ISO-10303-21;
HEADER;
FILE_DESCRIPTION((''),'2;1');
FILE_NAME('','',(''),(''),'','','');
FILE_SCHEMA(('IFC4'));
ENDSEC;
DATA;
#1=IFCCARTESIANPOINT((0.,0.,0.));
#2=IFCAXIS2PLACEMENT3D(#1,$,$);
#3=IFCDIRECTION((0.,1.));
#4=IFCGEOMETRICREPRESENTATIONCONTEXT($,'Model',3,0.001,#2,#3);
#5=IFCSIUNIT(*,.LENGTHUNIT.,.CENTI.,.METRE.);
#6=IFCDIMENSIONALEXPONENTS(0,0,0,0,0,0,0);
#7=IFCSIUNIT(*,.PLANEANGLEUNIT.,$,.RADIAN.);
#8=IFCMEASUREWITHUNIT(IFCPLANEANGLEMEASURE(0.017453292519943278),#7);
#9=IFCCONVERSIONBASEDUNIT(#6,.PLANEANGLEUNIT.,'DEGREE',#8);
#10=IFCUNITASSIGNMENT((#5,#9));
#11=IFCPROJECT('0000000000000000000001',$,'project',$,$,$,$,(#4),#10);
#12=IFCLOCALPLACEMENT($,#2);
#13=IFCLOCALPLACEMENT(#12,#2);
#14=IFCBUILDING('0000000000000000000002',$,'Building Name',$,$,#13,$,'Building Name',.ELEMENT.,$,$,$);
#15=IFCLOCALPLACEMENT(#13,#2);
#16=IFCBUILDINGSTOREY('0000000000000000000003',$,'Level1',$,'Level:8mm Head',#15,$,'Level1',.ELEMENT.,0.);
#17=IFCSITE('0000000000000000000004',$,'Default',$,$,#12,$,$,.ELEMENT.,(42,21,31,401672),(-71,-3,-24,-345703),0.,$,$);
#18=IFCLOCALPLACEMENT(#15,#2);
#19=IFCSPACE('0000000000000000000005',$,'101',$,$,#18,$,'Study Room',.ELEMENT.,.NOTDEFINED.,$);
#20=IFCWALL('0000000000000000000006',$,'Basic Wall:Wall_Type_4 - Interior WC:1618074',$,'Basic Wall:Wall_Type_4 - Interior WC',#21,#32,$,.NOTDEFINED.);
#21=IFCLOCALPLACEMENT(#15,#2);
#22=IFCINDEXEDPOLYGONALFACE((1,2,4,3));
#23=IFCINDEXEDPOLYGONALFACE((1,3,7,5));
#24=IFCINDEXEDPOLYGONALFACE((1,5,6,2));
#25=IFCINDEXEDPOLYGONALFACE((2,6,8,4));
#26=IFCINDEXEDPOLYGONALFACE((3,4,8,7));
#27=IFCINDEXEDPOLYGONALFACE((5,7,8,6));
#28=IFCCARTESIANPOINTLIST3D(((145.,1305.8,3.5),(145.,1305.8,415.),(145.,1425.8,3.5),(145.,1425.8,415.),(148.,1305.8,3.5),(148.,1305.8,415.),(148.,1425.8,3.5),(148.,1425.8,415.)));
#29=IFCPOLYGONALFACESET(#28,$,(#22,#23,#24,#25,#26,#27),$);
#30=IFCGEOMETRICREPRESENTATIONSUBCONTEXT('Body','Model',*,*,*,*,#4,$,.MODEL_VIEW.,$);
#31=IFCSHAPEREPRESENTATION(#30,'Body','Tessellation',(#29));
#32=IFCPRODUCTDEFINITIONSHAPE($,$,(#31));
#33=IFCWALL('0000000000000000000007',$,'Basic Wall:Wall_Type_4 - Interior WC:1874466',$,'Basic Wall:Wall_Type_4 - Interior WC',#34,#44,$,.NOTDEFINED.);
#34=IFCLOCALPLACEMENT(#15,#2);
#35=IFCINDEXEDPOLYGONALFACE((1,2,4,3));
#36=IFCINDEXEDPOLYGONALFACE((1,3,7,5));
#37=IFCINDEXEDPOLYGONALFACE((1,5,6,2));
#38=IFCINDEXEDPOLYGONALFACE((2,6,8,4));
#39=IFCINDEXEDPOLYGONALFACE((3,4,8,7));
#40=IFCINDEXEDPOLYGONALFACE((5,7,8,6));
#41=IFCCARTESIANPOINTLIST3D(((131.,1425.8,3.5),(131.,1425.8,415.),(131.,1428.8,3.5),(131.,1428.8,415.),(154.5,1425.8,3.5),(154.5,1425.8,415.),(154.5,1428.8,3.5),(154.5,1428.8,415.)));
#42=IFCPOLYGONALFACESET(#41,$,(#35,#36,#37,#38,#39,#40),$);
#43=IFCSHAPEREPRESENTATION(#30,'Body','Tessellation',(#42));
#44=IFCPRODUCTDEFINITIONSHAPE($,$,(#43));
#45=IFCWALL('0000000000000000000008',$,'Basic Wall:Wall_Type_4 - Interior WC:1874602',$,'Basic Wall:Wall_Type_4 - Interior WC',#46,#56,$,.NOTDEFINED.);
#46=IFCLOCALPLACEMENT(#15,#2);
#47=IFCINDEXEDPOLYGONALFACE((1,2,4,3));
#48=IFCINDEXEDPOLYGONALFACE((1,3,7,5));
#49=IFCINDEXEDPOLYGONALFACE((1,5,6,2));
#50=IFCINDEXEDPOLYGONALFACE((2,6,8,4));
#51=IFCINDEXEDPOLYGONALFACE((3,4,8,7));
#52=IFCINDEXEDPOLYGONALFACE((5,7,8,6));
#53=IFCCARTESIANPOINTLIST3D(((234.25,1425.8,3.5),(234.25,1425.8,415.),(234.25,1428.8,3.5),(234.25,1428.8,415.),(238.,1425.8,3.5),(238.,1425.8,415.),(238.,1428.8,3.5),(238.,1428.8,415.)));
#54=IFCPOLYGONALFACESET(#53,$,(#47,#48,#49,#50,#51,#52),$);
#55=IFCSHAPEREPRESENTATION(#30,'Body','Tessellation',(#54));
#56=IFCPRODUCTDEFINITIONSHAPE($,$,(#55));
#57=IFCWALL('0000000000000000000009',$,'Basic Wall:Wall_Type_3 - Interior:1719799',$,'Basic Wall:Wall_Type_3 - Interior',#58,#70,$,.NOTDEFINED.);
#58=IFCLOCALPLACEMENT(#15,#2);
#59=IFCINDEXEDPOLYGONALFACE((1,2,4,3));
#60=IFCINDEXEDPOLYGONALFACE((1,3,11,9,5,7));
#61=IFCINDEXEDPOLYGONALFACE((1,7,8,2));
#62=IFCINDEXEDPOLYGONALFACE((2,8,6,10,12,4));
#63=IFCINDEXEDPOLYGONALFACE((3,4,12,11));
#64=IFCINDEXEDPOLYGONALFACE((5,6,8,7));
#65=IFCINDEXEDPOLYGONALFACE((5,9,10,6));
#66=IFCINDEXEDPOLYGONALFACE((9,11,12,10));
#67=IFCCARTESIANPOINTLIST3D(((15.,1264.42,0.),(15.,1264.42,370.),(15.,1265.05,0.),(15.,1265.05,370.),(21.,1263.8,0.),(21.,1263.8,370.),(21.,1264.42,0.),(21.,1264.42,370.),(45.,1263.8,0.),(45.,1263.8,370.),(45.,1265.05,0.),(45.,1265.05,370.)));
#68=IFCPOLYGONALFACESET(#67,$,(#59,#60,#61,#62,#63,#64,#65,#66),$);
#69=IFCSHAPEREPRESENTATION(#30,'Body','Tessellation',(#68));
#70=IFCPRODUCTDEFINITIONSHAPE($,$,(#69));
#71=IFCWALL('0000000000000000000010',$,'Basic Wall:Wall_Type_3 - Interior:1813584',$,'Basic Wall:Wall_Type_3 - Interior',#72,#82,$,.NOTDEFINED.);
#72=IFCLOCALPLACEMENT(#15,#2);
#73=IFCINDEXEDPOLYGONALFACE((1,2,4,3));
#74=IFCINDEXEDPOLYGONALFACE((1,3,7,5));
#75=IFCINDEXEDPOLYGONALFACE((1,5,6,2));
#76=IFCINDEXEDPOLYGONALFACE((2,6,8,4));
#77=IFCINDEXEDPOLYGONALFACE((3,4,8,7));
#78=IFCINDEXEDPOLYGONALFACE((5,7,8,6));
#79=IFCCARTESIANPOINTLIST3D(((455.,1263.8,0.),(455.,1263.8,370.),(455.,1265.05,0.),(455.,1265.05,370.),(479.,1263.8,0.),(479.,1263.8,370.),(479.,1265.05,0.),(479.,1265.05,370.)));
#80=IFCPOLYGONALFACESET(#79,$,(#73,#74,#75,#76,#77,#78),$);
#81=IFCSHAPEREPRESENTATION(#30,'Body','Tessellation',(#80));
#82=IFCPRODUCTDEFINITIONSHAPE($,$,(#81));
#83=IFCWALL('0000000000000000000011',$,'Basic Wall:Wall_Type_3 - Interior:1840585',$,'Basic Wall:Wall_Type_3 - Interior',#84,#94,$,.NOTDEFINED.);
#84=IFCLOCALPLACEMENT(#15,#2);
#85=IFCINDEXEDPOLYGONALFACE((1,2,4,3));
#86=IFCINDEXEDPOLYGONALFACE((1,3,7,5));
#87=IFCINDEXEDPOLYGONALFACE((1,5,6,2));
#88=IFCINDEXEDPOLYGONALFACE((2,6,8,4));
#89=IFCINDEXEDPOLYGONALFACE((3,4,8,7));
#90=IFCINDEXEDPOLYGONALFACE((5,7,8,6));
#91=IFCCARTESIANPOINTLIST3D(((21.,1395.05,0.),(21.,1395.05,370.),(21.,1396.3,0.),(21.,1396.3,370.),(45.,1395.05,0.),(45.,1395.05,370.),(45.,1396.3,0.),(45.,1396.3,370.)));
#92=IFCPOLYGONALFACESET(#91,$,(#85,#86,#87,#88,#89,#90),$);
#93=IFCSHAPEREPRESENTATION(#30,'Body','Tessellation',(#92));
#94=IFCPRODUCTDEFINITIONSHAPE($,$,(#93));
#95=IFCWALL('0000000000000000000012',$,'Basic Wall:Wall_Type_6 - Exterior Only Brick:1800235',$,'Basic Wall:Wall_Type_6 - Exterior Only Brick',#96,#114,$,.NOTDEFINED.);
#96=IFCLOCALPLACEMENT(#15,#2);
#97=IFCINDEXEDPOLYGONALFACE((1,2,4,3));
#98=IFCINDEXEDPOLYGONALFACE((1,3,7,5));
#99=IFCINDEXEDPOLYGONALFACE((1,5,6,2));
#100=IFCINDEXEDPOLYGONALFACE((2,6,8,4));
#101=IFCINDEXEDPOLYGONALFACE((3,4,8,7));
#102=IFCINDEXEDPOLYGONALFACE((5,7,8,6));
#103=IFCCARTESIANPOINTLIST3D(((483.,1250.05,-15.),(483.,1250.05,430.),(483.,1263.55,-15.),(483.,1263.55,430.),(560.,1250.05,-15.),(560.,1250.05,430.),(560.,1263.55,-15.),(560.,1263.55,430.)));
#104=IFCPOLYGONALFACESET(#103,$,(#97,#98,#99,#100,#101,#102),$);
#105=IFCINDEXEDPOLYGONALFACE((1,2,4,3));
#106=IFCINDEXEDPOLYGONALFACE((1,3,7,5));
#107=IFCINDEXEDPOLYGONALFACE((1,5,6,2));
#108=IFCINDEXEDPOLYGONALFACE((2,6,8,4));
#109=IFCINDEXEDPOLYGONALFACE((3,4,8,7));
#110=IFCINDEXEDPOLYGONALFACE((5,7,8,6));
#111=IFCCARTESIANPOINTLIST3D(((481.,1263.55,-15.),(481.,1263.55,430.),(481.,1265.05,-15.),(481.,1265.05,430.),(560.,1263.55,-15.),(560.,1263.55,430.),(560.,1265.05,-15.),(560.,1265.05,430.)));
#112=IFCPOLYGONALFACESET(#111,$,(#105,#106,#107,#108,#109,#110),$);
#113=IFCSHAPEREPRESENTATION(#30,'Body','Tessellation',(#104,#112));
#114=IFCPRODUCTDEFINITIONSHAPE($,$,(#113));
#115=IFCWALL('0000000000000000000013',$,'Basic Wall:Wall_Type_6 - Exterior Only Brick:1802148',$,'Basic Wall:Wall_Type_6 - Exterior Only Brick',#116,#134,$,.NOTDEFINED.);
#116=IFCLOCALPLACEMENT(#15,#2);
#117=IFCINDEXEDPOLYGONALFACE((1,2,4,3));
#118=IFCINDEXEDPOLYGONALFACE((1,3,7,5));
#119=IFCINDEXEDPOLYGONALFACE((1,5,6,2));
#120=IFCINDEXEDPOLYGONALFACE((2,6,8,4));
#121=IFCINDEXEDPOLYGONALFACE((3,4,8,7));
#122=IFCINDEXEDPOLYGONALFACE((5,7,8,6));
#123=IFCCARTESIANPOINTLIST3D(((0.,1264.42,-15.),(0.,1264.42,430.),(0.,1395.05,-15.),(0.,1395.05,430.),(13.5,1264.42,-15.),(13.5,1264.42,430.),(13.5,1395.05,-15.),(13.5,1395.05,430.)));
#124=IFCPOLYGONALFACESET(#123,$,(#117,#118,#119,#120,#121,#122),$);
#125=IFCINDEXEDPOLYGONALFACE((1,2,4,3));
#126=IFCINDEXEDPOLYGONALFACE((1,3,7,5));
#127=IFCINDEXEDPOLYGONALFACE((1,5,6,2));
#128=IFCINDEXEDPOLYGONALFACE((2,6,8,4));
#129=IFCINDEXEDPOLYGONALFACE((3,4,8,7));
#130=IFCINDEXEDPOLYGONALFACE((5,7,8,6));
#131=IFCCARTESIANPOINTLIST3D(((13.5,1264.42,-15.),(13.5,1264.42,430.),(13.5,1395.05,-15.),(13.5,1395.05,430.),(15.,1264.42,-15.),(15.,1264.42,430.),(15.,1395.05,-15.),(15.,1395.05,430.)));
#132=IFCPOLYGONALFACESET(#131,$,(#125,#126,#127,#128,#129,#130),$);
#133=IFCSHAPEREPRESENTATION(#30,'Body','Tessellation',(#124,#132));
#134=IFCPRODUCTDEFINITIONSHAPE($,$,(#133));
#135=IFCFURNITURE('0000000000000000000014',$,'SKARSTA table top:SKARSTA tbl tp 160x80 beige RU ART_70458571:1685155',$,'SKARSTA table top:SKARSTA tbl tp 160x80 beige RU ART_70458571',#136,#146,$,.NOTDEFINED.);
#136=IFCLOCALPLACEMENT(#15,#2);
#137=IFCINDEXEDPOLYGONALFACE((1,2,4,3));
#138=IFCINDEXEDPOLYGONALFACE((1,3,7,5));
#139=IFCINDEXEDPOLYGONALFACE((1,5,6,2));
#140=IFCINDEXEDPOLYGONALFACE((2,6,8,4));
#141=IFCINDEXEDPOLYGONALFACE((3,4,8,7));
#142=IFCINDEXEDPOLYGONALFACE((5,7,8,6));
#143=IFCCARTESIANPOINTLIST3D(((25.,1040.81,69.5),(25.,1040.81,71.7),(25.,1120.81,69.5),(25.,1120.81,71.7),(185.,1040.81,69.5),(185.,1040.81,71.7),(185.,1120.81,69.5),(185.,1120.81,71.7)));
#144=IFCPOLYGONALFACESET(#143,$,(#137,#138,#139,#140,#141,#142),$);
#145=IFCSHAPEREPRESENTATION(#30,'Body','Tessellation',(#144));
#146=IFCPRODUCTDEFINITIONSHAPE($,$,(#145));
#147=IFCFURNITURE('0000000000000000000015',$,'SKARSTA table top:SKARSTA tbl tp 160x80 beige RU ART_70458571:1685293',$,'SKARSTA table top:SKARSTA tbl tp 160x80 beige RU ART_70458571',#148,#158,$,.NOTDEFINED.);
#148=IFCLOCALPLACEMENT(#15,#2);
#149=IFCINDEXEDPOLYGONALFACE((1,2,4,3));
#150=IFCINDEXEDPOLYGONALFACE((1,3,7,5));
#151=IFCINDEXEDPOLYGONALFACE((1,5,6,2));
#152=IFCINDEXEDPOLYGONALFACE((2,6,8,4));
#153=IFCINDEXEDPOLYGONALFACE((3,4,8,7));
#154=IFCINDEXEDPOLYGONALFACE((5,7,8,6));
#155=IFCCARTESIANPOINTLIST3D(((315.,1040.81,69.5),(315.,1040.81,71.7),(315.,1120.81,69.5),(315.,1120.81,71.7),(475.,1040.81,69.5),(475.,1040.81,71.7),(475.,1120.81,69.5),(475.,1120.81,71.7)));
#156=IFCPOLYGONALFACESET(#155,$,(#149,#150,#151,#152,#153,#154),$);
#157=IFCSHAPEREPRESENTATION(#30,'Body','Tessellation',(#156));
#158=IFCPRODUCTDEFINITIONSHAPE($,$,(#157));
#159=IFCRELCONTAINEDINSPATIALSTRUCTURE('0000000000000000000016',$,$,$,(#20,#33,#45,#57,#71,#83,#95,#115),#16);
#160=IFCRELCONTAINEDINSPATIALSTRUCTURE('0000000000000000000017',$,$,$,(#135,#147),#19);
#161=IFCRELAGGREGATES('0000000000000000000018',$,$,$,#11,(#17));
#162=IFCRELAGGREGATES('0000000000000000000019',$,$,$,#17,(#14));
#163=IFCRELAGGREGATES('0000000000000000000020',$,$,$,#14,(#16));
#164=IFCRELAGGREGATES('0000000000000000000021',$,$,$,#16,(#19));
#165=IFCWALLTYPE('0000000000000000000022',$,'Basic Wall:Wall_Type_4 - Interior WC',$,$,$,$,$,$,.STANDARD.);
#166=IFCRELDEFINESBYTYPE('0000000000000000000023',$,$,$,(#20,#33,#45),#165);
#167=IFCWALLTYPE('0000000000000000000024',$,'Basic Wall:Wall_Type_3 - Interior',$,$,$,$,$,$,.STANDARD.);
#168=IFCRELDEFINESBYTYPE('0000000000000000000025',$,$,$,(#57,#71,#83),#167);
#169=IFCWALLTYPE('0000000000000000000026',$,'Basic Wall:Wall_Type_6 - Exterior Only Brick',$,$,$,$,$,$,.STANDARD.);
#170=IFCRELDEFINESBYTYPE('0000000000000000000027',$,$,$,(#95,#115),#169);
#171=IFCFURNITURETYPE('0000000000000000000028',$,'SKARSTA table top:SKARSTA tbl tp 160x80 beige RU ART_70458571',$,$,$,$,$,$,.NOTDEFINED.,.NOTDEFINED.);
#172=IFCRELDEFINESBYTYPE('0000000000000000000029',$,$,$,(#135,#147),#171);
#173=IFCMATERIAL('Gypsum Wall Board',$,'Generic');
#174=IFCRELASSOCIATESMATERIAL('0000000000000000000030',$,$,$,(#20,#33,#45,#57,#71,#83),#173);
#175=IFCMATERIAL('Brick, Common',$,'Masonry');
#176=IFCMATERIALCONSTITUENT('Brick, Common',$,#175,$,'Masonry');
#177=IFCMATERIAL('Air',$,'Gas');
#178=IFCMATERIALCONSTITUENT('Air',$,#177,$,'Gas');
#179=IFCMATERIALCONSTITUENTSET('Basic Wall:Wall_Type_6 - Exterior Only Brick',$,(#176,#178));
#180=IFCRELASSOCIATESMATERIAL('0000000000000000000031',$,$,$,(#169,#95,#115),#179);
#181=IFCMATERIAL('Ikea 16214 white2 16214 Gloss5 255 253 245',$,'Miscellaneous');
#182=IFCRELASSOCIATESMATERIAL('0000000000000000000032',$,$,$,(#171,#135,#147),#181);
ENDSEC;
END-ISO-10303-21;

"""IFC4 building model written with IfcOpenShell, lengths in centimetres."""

from ifc_helpers import new_model, entity, si_unit, converted_unit, direction, frame, origin, place, context, subcontext, project, spatial, indexed_curve, outline, extrude, source, transform, mapped, material, constituent, constituent_set, type_object, type_shapes, element, save


model = new_model("IFC4")

# Units and contexts
model_context = context("Model", 3, precision=0.001, world=origin(), true_north=direction((0.0, 1.0)))
body_context = subcontext(model_context, "Body", "Model", "MODEL_VIEW")
ifc_project = project(units=[si_unit("LENGTHUNIT", "METRE", prefix="CENTI"), converted_unit("PLANEANGLEUNIT", "DEGREE", entity("IfcPlaneAngleMeasure", 0.017453292519943278), si_unit("PLANEANGLEUNIT", "RADIAN"), dimensions=[0, 0, 0, 0, 0, 0, 0])], contexts=[model_context])

# Site, building, storey
site_placement = place(None, origin())
site = spatial("IfcSite", under=ifc_project, at=site_placement, Name="Default", CompositionType="ELEMENT", RefLatitude=(42, 21, 31, 401672), RefLongitude=(-71, -3, -24, -345703), RefElevation=0.0)
building_placement = place(site_placement, origin())
building = spatial("IfcBuilding", under=site, at=building_placement, Name="Building Name", LongName="Building Name", CompositionType="ELEMENT")
storey_placement = place(building_placement, origin())
storey = spatial("IfcBuildingStorey", under=building, at=storey_placement, Name="Level1", ObjectType="Level:8mm Head", LongName="Level1", CompositionType="ELEMENT", Elevation=0.0)

# Shared definitions
ifc_material_1 = material(Name="Brick, Common", Category="Masonry")
ifc_material_2 = material(Name="Air", Category="Gas")
ifc_material_3 = material(Name="Gypsum Wall Board", Category="Generic")

# Walls
wall_type_1 = type_object("IfcWallType", Name="Basic Wall:Wall_Type_4 - Interior WC", PredefinedType="STANDARD")
wall_1_placement = place(storey_placement, frame((146.5, 1425.8, 3.5), z_axis=(0.0, 0.0, 1.0), x_axis=(0.0, -1.0, 0.0)))
element("IfcWall", 1, at=wall_1_placement, inside=storey, type_object=wall_type_1, material=ifc_material_3, Name="Basic Wall:Wall_Type_4 - Interior WC:1618074", ObjectType="Basic Wall:Wall_Type_4 - Interior WC", PredefinedType="NOTDEFINED", context=body_context, shape_type="SweptSolid", body=[
    extrude(outline(indexed_curve([(120.0, 1.5), (0.0, 1.5), (0.0, -1.5), (120.0, -1.5), (120.0, 1.5)], self_intersect=False)), origin(), (0.0, 0.0, 1.0), 411.5),
])
wall_2_placement = place(storey_placement, frame((131.0, 1427.3, 3.5)))
element("IfcWall", 2, at=wall_2_placement, inside=storey, type_object=wall_type_1, material=ifc_material_3, Name="Basic Wall:Wall_Type_4 - Interior WC:1874466", ObjectType="Basic Wall:Wall_Type_4 - Interior WC", PredefinedType="NOTDEFINED", context=body_context, shape_type="SweptSolid", body=[
    extrude(outline(indexed_curve([(23.5, 1.5), (0.0, 1.5), (0.0, -1.5), (23.5, -1.5), (23.5, 1.5)], self_intersect=False)), origin(), (0.0, 0.0, 1.0), 411.5),
])
wall_3_placement = place(storey_placement, frame((234.25, 1427.3, 3.5)))
element("IfcWall", 3, at=wall_3_placement, inside=storey, type_object=wall_type_1, material=ifc_material_3, Name="Basic Wall:Wall_Type_4 - Interior WC:1874602", ObjectType="Basic Wall:Wall_Type_4 - Interior WC", PredefinedType="NOTDEFINED", context=body_context, shape_type="SweptSolid", body=[
    extrude(outline(indexed_curve([(3.75, 1.5), (0.0, 1.5), (0.0, -1.5), (3.75, -1.5), (3.75, 1.5)], self_intersect=False)), origin(), (0.0, 0.0, 1.0), 411.5),
])
wall_type_2 = type_object("IfcWallType", Name="Basic Wall:Wall_Type_3 - Interior", PredefinedType="STANDARD")
wall_4_placement = place(storey_placement, frame((15.0, 1264.42, 0.0)))
element("IfcWall", 4, at=wall_4_placement, inside=storey, type_object=wall_type_2, material=ifc_material_3, Name="Basic Wall:Wall_Type_3 - Interior:1719799", ObjectType="Basic Wall:Wall_Type_3 - Interior", PredefinedType="NOTDEFINED", context=body_context, shape_type="SweptSolid", body=[
    extrude(outline(indexed_curve([(-0.62, -18.0), (0.63, -18.0), (0.63, 12.0), (0.0, 12.0), (0.0, 6.0), (-0.62, 6.0), (-0.62, -18.0)], self_intersect=False)), frame((12.0, 0.0, 0.0), z_axis=(0.0, 0.0, 1.0), x_axis=(0.0, 1.0, 0.0)), (0.0, 0.0, 1.0), 370.0),
])
wall_5_placement = place(storey_placement, frame((455.0, 1264.42, 0.0)))
element("IfcWall", 5, at=wall_5_placement, inside=storey, type_object=wall_type_2, material=ifc_material_3, Name="Basic Wall:Wall_Type_3 - Interior:1813584", ObjectType="Basic Wall:Wall_Type_3 - Interior", PredefinedType="NOTDEFINED", context=body_context, shape_type="SweptSolid", body=[
    extrude(outline(indexed_curve([(24.0, 0.63), (0.0, 0.63), (0.0, -0.63), (24.0, -0.63), (24.0, 0.63)], self_intersect=False)), origin(), (0.0, 0.0, 1.0), 370.0),
])
wall_6_placement = place(storey_placement, frame((45.0, 1395.67, 0.0), z_axis=(0.0, 0.0, 1.0), x_axis=(-1.0, 0.0, 0.0)))
element("IfcWall", 6, at=wall_6_placement, inside=storey, type_object=wall_type_2, material=ifc_material_3, Name="Basic Wall:Wall_Type_3 - Interior:1840585", ObjectType="Basic Wall:Wall_Type_3 - Interior", PredefinedType="NOTDEFINED", context=body_context, shape_type="SweptSolid", body=[
    extrude(outline(indexed_curve([(24.0, 0.63), (0.0, 0.63), (0.0, -0.63), (24.0, -0.63), (24.0, 0.63)], self_intersect=False)), origin(), (0.0, 0.0, 1.0), 370.0),
])
ifc_constituent_1 = constituent(ifc_material_1, Name="Brick, Common", Category="Masonry")
ifc_constituent_2 = constituent(ifc_material_2, Name="Air", Category="Gas")
ifc_constituent_set_1 = constituent_set(constituents=[ifc_constituent_1, ifc_constituent_2], Name="Basic Wall:Wall_Type_6 - Exterior Only Brick")
wall_type_3 = type_object("IfcWallType", Name="Basic Wall:Wall_Type_6 - Exterior Only Brick", PredefinedType="STANDARD", material=ifc_constituent_set_1)
wall_7_placement = place(storey_placement, frame((560.0, 1257.55, -15.0), z_axis=(0.0, 0.0, 1.0), x_axis=(-1.0, 0.0, 0.0)))
element("IfcWall", 7, at=wall_7_placement, inside=storey, type_object=wall_type_3, material=ifc_constituent_set_1, Name="Basic Wall:Wall_Type_6 - Exterior Only Brick:1800235", ObjectType="Basic Wall:Wall_Type_6 - Exterior Only Brick", PredefinedType="NOTDEFINED", context=body_context, shape_type="SweptSolid", body=[
    extrude(outline(indexed_curve([(-6.75, -38.5), (6.75, -38.5), (6.75, 38.5), (-6.75, 38.5), (-6.75, -38.5)], self_intersect=False)), frame((38.5, 0.75, 0.0), z_axis=(0.0, 0.0, 1.0), x_axis=(0.0, -1.0, 0.0)), (0.0, 0.0, 1.0), 445.0),
    extrude(outline(indexed_curve([(-0.75, -39.5), (0.75, -39.5), (0.75, 39.5), (-0.75, 39.5), (-0.75, -39.5)], self_intersect=False)), frame((39.5, -6.75, 0.0), z_axis=(0.0, 0.0, 1.0), x_axis=(0.0, -1.0, 0.0)), (0.0, 0.0, 1.0), 445.0),
])
wall_8_placement = place(storey_placement, frame((7.5, 1264.42, -15.0), z_axis=(0.0, 0.0, 1.0), x_axis=(0.0, 1.0, 0.0)))
element("IfcWall", 8, at=wall_8_placement, inside=storey, type_object=wall_type_3, material=ifc_constituent_set_1, Name="Basic Wall:Wall_Type_6 - Exterior Only Brick:1802148", ObjectType="Basic Wall:Wall_Type_6 - Exterior Only Brick", PredefinedType="NOTDEFINED", context=body_context, shape_type="SweptSolid", body=[
    extrude(outline(indexed_curve([(-6.75, -65.31), (6.75, -65.31), (6.75, 65.31), (-6.75, 65.31), (-6.75, -65.31)], self_intersect=False)), frame((65.31, 0.75, 0.0), z_axis=(0.0, 0.0, 1.0), x_axis=(0.0, -1.0, 0.0)), (0.0, 0.0, 1.0), 445.0),
    extrude(outline(indexed_curve([(-0.75, -65.31), (0.75, -65.31), (0.75, 65.31), (-0.75, 65.31), (-0.75, -65.31)], self_intersect=False)), frame((65.31, -6.75, 0.0), z_axis=(0.0, 0.0, 1.0), x_axis=(0.0, -1.0, 0.0)), (0.0, 0.0, 1.0), 445.0),
])

# Shared definitions
space_1_placement = place(storey_placement, origin())
space_1 = spatial("IfcSpace", under=storey, at=space_1_placement, Name="101", LongName="Study Room", CompositionType="ELEMENT", PredefinedType="NOTDEFINED")

# Furniture
ifc_material_4 = material(Name="Ikea 16214 white2 16214 Gloss5 255 253 245", Category="Miscellaneous")
furniture_type = type_object("IfcFurnitureType", Name="SKARSTA table top:SKARSTA tbl tp 160x80 beige RU ART_70458571", AssemblyPlace="NOTDEFINED", PredefinedType="NOTDEFINED", material=ifc_material_4)
shared_shape_1 = source(origin(), body_context, "Body", "SweptSolid", [
    extrude(outline(indexed_curve([(-80.0, -40.0), (80.0, -40.0), (80.0, 40.0), (-80.0, 40.0), (-80.0, -40.0)], self_intersect=False)), frame((0.0, 0.0, 0.0), z_axis=(0.0, 0.0, 1.0), x_axis=(-1.0, 0.0, 0.0)), (0.0, 0.0, 1.0), 2.2),
])
type_shapes(furniture_type, [shared_shape_1])
for number, where, z_axis, x_axis, name in (
    (9, (105.0, 1080.81, 69.5), (0.0, 0.0, 1.0), (-1.0, 0.0, 0.0), "SKARSTA table top:SKARSTA tbl tp 160x80 beige RU ART_70458571:1685155"),
    (10, (395.0, 1080.81, 69.5), (0.0, 0.0, 1.0), (-1.0, 0.0, 0.0), "SKARSTA table top:SKARSTA tbl tp 160x80 beige RU ART_70458571:1685293"),
):
    element("IfcFurniture", number, at=place(space_1_placement, frame(where, z_axis=z_axis, x_axis=x_axis)), inside=space_1, type_object=furniture_type, material=ifc_material_4, Name=name, ObjectType="SKARSTA table top:SKARSTA tbl tp 160x80 beige RU ART_70458571", PredefinedType="NOTDEFINED", context=body_context, shape_type="MappedRepresentation", body=[
        mapped(shared_shape_1, transform((0.0, 0.0, 0.0), scale=1.0)),
    ])

save(model, "model.ifc")
